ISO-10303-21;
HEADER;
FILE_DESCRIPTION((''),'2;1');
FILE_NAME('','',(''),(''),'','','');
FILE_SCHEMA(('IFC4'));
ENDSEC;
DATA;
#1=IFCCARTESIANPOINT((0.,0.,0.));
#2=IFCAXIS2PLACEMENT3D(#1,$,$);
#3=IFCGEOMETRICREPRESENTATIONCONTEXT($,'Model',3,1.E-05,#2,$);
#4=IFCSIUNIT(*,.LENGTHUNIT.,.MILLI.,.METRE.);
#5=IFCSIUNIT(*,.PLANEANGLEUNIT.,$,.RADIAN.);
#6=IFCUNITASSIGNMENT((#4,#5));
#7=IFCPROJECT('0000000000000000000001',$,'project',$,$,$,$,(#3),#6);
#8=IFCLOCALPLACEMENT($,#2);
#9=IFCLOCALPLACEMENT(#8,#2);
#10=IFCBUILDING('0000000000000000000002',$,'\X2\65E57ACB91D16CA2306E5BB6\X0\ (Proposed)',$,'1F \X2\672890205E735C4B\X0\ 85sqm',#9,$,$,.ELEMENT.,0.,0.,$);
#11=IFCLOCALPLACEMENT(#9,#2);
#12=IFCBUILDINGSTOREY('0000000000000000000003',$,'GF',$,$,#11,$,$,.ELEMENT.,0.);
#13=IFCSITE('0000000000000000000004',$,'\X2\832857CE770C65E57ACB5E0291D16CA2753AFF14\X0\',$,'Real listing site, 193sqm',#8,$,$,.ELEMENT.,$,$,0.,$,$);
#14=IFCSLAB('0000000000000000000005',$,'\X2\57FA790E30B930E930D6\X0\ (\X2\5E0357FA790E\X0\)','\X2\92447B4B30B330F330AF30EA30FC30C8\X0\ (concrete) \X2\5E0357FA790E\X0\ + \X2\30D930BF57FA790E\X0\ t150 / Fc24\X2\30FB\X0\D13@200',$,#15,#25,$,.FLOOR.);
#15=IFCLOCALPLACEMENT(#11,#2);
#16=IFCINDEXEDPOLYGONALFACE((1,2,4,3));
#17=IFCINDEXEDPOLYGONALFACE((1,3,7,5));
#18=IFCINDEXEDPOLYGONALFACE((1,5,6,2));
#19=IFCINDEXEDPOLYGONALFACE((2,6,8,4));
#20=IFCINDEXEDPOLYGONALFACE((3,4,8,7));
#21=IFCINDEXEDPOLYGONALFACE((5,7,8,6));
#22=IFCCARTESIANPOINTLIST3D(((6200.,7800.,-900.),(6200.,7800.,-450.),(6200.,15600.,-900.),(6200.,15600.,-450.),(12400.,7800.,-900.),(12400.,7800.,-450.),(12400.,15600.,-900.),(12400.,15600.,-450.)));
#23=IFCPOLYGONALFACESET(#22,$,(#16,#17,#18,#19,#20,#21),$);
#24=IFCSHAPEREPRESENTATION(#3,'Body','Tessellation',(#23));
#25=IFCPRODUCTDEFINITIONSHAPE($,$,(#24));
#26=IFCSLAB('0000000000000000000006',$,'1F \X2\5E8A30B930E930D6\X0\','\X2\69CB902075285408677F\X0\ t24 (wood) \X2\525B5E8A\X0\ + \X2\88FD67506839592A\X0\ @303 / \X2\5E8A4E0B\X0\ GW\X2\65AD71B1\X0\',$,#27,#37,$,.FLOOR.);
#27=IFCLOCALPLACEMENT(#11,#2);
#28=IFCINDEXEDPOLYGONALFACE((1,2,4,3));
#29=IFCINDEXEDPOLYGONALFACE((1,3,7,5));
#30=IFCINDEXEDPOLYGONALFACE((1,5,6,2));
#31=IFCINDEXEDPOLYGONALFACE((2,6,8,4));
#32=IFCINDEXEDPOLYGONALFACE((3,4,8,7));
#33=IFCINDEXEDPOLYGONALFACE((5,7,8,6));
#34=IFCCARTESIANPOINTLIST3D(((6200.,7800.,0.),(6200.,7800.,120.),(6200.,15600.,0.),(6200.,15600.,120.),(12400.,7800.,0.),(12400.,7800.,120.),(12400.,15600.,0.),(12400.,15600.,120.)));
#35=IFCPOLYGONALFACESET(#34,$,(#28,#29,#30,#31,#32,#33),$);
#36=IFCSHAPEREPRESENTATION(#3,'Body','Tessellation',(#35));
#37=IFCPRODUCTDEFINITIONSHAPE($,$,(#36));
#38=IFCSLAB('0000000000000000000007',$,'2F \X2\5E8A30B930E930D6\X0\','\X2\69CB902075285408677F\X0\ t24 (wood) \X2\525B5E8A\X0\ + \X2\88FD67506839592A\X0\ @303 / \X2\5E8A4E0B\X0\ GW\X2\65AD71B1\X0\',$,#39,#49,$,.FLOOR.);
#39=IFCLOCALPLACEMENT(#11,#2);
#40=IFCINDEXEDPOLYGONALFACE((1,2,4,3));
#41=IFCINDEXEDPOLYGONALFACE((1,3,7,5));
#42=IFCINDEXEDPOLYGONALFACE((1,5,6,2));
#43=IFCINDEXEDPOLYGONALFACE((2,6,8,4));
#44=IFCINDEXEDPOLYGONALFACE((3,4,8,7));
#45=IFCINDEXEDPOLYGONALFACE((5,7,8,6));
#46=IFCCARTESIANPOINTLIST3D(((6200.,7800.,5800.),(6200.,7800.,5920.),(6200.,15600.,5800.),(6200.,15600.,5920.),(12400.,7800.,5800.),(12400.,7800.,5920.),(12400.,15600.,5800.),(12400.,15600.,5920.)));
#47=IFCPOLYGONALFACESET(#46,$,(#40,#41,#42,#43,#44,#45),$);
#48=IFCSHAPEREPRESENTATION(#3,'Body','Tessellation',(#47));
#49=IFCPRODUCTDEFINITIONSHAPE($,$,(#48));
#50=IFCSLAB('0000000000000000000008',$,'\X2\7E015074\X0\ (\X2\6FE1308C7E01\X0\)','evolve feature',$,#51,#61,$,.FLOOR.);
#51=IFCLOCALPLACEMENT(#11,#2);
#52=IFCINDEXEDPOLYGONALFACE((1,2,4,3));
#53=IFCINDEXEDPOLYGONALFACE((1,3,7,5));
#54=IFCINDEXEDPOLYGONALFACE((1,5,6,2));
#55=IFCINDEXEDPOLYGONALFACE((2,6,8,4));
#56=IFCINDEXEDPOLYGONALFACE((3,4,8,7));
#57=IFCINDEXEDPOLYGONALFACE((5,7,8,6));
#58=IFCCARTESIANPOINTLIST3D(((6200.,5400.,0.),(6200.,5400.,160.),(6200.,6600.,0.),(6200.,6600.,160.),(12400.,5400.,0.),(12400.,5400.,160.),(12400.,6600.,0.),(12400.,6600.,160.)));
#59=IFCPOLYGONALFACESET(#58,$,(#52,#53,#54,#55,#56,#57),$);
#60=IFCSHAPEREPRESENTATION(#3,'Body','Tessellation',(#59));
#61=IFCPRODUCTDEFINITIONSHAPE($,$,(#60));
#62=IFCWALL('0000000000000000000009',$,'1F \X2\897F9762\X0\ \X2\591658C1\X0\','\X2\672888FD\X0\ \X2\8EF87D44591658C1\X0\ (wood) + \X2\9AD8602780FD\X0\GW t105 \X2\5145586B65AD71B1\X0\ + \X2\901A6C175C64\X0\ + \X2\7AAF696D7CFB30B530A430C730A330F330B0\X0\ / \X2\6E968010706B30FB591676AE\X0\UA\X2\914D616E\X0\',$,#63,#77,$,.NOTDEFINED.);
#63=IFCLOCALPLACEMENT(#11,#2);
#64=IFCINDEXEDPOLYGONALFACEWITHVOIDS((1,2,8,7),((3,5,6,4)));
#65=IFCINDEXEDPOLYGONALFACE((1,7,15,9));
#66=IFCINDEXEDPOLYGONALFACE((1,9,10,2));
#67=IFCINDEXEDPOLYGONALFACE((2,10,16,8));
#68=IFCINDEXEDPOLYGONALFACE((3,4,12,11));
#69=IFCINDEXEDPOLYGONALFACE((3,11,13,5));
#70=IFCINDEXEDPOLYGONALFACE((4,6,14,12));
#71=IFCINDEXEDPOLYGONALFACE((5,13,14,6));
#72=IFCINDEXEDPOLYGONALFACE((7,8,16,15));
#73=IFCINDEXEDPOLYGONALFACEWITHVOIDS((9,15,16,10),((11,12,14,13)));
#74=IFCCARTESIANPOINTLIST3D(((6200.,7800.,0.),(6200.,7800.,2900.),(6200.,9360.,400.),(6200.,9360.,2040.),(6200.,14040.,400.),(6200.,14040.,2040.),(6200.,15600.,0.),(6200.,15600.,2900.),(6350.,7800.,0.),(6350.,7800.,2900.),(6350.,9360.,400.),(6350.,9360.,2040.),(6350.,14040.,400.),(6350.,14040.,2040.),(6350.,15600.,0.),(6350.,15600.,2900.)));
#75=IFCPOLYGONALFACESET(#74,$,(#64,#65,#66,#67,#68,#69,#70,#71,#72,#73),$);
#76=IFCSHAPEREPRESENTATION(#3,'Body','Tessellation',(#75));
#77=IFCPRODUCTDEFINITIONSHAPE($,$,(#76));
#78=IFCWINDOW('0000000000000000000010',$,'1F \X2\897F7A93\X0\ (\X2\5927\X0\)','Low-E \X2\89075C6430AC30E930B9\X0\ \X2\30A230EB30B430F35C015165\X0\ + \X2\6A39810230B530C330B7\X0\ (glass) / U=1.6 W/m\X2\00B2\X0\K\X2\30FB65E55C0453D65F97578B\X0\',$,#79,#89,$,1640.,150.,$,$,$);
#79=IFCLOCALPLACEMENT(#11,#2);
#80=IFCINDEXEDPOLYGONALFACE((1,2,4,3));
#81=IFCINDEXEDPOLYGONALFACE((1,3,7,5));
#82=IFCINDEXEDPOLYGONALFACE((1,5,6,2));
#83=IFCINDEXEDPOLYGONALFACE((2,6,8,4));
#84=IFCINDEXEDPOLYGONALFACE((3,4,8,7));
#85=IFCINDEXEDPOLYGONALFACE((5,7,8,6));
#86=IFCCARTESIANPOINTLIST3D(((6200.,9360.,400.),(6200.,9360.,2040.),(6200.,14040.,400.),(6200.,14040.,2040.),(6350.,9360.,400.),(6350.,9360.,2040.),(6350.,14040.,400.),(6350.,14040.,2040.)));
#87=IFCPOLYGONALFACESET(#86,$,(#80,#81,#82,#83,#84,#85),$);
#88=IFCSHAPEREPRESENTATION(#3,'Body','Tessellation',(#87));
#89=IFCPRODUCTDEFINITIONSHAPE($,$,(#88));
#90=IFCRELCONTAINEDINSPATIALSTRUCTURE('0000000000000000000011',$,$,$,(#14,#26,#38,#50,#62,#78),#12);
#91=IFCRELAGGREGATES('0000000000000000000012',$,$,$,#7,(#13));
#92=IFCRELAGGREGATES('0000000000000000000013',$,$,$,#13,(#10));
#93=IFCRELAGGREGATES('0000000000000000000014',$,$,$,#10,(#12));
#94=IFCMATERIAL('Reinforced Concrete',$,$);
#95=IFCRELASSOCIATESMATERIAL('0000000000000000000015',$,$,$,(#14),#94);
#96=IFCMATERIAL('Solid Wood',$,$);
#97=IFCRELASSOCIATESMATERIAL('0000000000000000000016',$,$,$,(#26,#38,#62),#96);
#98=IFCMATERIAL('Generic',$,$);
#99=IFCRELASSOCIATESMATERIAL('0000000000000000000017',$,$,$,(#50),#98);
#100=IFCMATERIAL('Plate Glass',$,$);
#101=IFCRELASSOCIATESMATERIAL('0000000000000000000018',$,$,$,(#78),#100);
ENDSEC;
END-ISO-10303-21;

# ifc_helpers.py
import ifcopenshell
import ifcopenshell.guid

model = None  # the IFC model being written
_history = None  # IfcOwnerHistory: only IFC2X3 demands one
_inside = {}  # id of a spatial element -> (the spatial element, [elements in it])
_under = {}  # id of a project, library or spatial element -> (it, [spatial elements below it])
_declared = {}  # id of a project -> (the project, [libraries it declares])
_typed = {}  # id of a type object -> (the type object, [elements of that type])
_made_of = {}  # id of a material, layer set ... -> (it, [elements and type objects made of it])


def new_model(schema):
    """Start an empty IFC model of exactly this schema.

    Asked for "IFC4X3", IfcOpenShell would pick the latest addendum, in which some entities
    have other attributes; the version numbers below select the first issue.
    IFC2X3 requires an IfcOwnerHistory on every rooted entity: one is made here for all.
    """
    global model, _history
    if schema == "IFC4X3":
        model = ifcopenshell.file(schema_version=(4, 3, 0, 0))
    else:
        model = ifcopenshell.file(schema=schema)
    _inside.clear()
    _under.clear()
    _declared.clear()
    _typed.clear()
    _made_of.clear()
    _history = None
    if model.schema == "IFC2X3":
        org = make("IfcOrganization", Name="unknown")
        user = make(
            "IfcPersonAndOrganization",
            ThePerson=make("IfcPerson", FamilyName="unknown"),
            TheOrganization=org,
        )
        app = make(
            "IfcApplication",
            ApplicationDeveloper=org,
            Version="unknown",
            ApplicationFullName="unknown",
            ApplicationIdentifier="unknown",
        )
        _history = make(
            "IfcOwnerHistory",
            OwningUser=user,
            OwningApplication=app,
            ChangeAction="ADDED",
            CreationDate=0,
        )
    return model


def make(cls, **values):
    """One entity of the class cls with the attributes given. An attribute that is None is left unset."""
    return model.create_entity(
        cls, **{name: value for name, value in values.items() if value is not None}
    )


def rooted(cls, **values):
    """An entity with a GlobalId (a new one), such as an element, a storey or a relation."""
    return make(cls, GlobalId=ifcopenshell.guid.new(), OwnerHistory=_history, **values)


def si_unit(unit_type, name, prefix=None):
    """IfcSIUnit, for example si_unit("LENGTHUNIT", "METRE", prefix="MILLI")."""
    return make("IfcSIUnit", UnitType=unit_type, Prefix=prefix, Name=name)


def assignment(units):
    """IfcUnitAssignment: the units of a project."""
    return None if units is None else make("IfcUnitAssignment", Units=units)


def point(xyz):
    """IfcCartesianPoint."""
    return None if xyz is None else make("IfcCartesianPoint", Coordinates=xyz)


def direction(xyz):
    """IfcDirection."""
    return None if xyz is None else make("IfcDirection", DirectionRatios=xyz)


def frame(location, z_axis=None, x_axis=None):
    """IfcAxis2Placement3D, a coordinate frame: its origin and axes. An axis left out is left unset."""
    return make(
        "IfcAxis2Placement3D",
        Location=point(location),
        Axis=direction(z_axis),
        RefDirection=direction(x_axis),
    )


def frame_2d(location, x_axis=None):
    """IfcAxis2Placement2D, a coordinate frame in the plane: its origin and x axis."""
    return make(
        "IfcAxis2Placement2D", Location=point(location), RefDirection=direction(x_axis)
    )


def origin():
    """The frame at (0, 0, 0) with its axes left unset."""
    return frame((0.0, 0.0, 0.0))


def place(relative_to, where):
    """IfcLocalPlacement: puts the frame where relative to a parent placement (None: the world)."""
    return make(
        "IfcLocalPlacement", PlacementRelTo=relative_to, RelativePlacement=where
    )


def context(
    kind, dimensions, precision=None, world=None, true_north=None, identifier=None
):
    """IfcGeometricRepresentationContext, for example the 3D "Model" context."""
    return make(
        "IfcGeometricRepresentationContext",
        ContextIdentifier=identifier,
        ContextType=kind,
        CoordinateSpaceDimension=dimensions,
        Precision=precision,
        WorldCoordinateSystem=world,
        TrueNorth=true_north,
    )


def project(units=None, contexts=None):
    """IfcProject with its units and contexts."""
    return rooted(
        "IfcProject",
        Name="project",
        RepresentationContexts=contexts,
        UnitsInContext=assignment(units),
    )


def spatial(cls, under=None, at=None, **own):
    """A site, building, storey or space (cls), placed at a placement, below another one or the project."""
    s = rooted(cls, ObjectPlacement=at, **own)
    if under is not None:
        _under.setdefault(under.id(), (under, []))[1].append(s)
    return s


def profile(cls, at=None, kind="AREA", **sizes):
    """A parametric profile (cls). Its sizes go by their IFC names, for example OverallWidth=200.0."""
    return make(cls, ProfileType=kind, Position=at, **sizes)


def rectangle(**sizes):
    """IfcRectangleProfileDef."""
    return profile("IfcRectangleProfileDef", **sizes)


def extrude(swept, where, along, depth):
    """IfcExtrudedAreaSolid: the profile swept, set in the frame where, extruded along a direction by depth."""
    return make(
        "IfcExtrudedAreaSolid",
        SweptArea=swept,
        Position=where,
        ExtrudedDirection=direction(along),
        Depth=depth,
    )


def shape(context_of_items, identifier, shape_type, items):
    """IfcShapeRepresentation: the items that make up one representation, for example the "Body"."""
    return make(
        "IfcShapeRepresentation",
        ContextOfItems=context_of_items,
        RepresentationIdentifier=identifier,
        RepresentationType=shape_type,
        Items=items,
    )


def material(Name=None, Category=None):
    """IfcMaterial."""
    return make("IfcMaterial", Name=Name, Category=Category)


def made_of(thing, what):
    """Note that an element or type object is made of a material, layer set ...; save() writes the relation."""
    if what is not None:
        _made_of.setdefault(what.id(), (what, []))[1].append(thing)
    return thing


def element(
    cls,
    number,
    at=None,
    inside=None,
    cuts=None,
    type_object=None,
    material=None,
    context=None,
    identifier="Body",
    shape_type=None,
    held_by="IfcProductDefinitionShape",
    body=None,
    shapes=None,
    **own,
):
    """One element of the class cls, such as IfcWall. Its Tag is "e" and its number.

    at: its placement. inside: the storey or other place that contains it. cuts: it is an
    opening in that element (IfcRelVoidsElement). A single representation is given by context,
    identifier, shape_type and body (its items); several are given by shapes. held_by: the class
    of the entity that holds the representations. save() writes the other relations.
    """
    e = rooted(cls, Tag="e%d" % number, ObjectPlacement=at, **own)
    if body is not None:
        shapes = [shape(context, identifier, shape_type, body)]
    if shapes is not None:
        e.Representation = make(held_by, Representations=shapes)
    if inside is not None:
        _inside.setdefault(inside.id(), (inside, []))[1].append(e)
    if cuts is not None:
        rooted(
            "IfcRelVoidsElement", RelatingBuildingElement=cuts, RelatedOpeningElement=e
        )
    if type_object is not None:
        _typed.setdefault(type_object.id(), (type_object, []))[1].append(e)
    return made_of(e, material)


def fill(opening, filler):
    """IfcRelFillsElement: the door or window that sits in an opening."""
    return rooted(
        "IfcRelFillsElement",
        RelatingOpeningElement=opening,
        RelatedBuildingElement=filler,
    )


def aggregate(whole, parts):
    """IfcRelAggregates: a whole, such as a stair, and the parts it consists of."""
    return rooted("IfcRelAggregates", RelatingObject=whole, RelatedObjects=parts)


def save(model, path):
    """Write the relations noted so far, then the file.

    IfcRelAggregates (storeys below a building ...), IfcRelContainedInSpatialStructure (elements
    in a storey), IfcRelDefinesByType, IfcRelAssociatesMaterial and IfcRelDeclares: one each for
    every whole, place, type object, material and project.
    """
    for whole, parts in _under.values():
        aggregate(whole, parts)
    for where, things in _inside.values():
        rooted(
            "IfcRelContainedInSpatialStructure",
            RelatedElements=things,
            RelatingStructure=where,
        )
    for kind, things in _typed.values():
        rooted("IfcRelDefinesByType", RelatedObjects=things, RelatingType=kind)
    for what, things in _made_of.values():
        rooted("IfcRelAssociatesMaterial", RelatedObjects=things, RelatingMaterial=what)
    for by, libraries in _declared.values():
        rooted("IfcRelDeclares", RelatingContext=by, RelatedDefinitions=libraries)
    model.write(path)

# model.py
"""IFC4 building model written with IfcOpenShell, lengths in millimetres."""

from ifc_helpers import new_model, si_unit, frame, frame_2d, origin, place, context, project, spatial, rectangle, extrude, material, element, fill, save


model = new_model("IFC4")

# Units and contexts
model_context = context("Model", 3, precision=1e-05, world=origin())
ifc_project = project(units=[si_unit("LENGTHUNIT", "METRE", prefix="MILLI"), si_unit("PLANEANGLEUNIT", "RADIAN")], contexts=[model_context])

# Site, building, storey
site_placement = place(None, origin())
site = spatial("IfcSite", under=ifc_project, at=site_placement, Name="茨城県日立市金沢町４", ObjectType="Real listing site, 193sqm", CompositionType="ELEMENT", RefElevation=0.0)
building_placement = place(site_placement, origin())
building = spatial("IfcBuilding", under=site, at=building_placement, Name="日立金沢の家 (Proposed)", ObjectType="1F 木造平屋 85sqm", CompositionType="ELEMENT", ElevationOfRefHeight=0.0, ElevationOfTerrain=0.0)
storey_placement = place(building_placement, origin())
storey = spatial("IfcBuildingStorey", under=building, at=storey_placement, Name="GF", CompositionType="ELEMENT", Elevation=0.0)

# Slabs
ifc_material_1 = material(Name="Reinforced Concrete")
slab_1_placement = place(storey_placement, frame((3100.0, 3900.0, -450.0)))
element("IfcSlab", 1, at=slab_1_placement, inside=storey, material=ifc_material_1, Name="基礎スラブ (布基礎)", Description="鉄筋コンクリート (concrete) 布基礎 + ベタ基礎 t150 / Fc24・D13@200", PredefinedType="FLOOR", context=model_context, shape_type="SweptSolid", body=[
    extrude(rectangle(XDim=6200.0, YDim=7800.0, at=frame_2d((3100.0, 3900.0))), frame((3100.0, 3900.0, -450.0)), (0.0, 0.0, 1.0), 450.0),
])
ifc_material_2 = material(Name="Solid Wood")
slab_2_placement = place(storey_placement, frame((3100.0, 3900.0, 0.0)))
element("IfcSlab", 2, at=slab_2_placement, inside=storey, material=ifc_material_2, Name="1F 床スラブ", Description="構造用合板 t24 (wood) 剛床 + 製材根太 @303 / 床下 GW断熱", PredefinedType="FLOOR", context=model_context, shape_type="SweptSolid", body=[
    extrude(rectangle(XDim=6200.0, YDim=7800.0, at=frame_2d((3100.0, 3900.0))), frame((3100.0, 3900.0, 0.0)), (0.0, 0.0, 1.0), 120.0),
])
slab_3_placement = place(storey_placement, frame((3100.0, 3900.0, 2900.0)))
element("IfcSlab", 3, at=slab_3_placement, inside=storey, material=ifc_material_2, Name="2F 床スラブ", Description="構造用合板 t24 (wood) 剛床 + 製材根太 @303 / 床下 GW断熱", PredefinedType="FLOOR", context=model_context, shape_type="SweptSolid", body=[
    extrude(rectangle(XDim=6200.0, YDim=7800.0, at=frame_2d((3100.0, 3900.0))), frame((3100.0, 3900.0, 2900.0)), (0.0, 0.0, 1.0), 120.0),
])
ifc_material_3 = material(Name="Generic")
slab_4_placement = place(storey_placement, frame((3100.0, 2700.0, 0.0)))
element("IfcSlab", 4, at=slab_4_placement, inside=storey, material=ifc_material_3, Name="縁側 (濡れ縁)", Description="evolve feature", PredefinedType="FLOOR", context=model_context, shape_type="SweptSolid", body=[
    extrude(rectangle(XDim=6200.0, YDim=1200.0, at=frame_2d((3100.0, 600.0))), frame((3100.0, 2700.0, 0.0)), (0.0, 0.0, 1.0), 160.0),
])

# Shared definitions
ifc_material_4 = material(Name="Plate Glass")

# Wall, opening, window
wall_1_placement = place(storey_placement, frame((3100.0, 3900.0, 0.0)))
wall_1 = element("IfcWall", 5, at=wall_1_placement, inside=storey, material=ifc_material_2, Name="1F 西面 外壁", Description="木製 軸組外壁 (wood) + 高性能GW t105 充填断熱 + 通気層 + 窯業系サイディング / 準耐火・外皮UA配慮", PredefinedType="NOTDEFINED", context=model_context, shape_type="SweptSolid", body=[
    extrude(rectangle(XDim=150.0, YDim=7800.0, at=frame_2d((75.0, 3900.0))), frame((3100.0, 3900.0, 0.0)), (0.0, 0.0, 1.0), 2900.0),
])
opening_1_placement = place(storey_placement, frame((3100.0, 4680.0, 200.0)))
opening_1 = element("IfcOpeningElement", 6, at=opening_1_placement, cuts=wall_1, PredefinedType="NOTDEFINED", context=model_context, shape_type="SweptSolid", body=[
    extrude(rectangle(XDim=150.0, YDim=4680.0, at=frame_2d((75.0, 2340.0))), frame((3100.0, 4680.0, 200.0)), (0.0, 0.0, 1.0), 1640.0),
])
window_1_placement = place(storey_placement, frame((3100.0, 4680.0, 200.0)))
window_1 = element("IfcWindow", 7, at=window_1_placement, inside=storey, material=ifc_material_4, Name="1F 西窓 (大)", Description="Low-E 複層ガラス アルゴン封入 + 樹脂サッシ (glass) / U=1.6 W/m²K・日射取得型", OverallHeight=1640.0, OverallWidth=150.0, context=model_context, shape_type="SweptSolid", body=[
    extrude(rectangle(XDim=150.0, YDim=4680.0, at=frame_2d((75.0, 2340.0))), frame((3100.0, 4680.0, 200.0)), (0.0, 0.0, 1.0), 1640.0),
])
fill(opening_1, window_1)

save(model, "model.ifc")
